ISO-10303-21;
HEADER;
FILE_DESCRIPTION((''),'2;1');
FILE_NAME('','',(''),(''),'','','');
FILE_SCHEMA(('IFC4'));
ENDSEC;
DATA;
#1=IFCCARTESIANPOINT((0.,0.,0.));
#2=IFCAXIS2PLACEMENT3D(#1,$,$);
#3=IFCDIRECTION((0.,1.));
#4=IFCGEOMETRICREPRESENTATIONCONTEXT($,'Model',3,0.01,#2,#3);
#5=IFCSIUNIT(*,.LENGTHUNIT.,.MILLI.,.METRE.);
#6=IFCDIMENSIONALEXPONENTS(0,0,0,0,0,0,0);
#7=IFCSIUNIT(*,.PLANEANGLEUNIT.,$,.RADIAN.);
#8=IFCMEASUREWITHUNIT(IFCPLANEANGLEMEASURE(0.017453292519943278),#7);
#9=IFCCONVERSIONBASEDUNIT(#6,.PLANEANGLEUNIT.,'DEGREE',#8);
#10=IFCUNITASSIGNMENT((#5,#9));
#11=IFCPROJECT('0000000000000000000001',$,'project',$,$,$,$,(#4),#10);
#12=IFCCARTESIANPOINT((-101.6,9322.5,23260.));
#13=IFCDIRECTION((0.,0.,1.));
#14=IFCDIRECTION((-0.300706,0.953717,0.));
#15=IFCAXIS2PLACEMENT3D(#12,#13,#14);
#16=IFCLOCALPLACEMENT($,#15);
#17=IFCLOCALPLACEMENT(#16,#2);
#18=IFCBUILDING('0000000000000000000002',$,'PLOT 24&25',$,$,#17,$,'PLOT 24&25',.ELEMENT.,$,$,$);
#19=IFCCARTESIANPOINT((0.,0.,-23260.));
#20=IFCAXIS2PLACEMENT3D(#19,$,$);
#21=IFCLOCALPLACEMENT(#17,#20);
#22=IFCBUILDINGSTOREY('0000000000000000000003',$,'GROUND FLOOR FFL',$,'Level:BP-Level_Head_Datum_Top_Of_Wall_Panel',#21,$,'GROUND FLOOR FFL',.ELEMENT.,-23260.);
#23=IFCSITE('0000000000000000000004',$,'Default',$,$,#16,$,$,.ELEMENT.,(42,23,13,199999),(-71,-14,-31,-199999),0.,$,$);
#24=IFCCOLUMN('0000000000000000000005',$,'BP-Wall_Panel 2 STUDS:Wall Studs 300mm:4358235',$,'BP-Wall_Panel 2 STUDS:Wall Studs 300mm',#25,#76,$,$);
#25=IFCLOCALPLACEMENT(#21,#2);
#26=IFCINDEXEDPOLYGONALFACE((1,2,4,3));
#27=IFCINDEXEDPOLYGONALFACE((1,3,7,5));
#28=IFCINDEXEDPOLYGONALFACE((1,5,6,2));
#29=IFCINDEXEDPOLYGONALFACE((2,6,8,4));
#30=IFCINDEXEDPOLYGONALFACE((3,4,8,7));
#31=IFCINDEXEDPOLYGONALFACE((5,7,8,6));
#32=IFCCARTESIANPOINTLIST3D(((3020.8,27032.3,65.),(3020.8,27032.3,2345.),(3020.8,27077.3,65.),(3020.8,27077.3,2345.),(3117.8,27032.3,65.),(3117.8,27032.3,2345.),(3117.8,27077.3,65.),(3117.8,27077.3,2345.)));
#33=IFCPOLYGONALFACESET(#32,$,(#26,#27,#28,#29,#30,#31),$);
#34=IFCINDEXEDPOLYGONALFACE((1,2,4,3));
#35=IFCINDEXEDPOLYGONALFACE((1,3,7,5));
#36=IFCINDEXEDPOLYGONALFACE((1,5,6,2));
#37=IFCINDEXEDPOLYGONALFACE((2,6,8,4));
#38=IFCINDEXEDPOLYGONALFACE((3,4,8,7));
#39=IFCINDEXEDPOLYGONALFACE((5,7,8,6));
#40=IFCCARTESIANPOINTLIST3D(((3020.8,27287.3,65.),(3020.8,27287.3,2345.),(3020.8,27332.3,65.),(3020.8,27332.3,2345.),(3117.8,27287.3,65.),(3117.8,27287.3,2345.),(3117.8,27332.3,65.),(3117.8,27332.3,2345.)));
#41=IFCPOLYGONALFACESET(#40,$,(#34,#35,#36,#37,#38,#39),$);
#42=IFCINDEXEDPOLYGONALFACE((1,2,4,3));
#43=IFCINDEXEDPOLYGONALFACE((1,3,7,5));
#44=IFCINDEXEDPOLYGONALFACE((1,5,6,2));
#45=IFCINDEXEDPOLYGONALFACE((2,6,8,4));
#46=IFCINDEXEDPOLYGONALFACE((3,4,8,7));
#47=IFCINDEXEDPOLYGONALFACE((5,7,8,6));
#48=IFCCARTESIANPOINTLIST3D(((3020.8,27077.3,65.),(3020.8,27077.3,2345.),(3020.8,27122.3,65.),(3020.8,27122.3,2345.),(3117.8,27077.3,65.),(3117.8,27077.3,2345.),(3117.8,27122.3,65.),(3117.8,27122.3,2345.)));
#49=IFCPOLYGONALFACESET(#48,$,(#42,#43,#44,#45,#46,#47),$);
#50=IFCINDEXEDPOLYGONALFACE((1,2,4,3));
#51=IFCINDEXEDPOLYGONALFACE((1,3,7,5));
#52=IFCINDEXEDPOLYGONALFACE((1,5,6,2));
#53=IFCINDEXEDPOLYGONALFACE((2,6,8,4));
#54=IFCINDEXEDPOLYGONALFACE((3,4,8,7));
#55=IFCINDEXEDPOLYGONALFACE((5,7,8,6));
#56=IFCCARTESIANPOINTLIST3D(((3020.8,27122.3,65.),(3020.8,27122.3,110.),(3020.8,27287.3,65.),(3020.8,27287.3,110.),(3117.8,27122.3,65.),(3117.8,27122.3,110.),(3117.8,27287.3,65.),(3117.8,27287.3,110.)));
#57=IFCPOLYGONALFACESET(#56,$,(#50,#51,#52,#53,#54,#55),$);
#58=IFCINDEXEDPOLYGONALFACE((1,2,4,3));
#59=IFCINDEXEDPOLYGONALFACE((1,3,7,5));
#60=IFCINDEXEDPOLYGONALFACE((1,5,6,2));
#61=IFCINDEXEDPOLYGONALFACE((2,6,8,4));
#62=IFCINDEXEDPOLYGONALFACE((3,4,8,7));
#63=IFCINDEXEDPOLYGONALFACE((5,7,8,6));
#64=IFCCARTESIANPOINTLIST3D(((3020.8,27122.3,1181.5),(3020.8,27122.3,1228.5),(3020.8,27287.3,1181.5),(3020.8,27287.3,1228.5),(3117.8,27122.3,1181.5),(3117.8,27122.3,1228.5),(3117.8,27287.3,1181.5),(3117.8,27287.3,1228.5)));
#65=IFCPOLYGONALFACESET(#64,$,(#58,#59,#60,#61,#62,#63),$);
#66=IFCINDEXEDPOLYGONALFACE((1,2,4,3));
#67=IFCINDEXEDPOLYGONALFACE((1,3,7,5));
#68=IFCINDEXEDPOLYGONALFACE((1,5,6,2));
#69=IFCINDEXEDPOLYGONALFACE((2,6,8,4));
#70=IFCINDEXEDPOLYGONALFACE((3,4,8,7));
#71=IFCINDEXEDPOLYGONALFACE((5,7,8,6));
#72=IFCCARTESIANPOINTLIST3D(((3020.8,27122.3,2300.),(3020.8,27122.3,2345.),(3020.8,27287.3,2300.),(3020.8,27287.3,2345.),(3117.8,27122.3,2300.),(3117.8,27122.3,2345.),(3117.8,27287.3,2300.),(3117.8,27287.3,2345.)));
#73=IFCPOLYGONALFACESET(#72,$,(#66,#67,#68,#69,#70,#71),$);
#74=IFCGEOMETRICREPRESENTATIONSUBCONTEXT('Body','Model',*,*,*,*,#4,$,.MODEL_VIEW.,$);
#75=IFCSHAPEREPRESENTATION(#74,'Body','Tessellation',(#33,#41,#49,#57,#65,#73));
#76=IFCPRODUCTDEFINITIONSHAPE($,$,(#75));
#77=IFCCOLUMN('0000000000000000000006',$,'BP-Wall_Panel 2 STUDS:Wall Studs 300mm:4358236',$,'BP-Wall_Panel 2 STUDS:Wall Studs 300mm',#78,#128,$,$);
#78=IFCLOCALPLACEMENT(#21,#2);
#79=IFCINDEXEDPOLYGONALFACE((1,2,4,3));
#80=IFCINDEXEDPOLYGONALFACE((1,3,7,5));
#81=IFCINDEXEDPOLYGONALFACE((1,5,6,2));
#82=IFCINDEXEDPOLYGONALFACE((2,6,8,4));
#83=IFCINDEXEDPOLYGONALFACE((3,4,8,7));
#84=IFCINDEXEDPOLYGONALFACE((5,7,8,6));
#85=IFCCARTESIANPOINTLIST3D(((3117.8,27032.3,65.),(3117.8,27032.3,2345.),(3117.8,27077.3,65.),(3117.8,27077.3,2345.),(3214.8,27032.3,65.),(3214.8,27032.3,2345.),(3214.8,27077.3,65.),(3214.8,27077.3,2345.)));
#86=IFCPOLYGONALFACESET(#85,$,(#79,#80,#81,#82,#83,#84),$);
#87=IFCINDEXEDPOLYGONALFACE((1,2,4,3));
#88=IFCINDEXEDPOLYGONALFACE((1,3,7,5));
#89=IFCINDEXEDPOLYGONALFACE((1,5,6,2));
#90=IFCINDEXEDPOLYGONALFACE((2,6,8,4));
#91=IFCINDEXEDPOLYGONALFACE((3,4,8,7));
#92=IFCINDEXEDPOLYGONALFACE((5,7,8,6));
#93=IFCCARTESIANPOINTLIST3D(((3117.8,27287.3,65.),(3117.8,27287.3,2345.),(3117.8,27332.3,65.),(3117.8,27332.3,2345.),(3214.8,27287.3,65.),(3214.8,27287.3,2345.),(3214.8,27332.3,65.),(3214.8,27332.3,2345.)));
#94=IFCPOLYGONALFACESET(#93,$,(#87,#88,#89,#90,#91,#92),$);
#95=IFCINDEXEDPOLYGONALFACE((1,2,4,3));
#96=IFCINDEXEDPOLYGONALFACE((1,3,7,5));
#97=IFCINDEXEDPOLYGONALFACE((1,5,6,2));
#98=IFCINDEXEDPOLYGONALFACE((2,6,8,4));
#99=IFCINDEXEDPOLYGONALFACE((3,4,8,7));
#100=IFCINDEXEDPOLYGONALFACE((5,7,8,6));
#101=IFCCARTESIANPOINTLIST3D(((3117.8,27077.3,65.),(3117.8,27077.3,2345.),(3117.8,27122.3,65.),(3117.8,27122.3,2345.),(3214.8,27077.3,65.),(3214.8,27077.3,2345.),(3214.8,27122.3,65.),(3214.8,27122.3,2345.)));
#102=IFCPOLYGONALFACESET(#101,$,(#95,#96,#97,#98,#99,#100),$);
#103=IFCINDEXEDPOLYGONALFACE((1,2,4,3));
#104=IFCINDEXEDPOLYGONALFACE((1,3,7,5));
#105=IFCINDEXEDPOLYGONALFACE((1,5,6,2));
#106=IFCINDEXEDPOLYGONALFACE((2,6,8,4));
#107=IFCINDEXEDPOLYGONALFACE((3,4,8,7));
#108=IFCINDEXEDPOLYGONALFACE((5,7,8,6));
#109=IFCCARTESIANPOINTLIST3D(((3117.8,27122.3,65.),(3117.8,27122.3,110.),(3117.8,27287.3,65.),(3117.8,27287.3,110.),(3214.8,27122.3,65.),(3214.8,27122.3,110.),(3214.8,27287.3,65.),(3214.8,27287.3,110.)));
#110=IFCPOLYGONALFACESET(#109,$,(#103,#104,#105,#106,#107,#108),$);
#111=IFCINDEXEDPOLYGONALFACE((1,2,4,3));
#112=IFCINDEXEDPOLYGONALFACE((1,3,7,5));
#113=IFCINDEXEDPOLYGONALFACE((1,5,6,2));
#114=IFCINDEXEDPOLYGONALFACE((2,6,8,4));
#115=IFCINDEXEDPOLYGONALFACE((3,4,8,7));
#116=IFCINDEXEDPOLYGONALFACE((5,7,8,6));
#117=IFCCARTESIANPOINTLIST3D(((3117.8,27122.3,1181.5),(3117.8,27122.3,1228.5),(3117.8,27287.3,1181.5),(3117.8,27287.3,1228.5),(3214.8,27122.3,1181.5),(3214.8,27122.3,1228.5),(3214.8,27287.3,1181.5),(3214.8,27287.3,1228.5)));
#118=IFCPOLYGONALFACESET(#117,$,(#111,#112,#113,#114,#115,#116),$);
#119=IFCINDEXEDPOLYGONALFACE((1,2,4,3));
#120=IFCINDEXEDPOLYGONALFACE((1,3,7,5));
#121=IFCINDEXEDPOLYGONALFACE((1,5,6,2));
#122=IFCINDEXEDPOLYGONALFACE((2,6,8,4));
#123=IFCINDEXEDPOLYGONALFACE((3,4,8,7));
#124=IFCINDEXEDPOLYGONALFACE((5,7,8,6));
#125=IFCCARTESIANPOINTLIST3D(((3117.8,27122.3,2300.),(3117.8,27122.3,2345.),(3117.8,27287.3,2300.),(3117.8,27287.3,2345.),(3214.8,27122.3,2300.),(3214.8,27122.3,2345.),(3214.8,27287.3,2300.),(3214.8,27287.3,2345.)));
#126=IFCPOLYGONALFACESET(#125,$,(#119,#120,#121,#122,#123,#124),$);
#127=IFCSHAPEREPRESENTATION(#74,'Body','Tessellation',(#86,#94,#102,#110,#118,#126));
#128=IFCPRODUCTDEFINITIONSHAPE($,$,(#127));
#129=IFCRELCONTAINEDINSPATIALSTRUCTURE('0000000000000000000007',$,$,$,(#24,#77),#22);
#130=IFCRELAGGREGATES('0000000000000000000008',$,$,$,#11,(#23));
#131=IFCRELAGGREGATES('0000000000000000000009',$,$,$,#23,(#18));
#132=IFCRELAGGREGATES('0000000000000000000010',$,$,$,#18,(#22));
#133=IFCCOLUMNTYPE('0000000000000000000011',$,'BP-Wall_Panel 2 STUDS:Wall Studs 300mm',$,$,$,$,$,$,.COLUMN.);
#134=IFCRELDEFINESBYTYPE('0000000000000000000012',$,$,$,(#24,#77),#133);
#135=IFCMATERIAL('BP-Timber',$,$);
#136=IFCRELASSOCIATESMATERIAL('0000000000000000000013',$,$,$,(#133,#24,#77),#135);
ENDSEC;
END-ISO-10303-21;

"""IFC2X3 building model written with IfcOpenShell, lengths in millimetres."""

from ifc_helpers import new_model, entity, si_unit, converted_unit, direction, frame, frame_2d, origin, origin_2d_with_axis, place, context, subcontext, project, spatial, rectangle, extrude, source, transform, mapped, material, type_object, type_shapes, element, save


model = new_model("IFC2X3")

# Units and contexts
model_context = context("Model", 3, precision=0.01, world=origin(), true_north=direction((0.0, 1.0)))
body_context = subcontext(model_context, "Body", "Model", "MODEL_VIEW")
ifc_project = project(units=[si_unit("LENGTHUNIT", "METRE", prefix="MILLI"), converted_unit("PLANEANGLEUNIT", "DEGREE", entity("IfcPlaneAngleMeasure", 0.017453292519943278), si_unit("PLANEANGLEUNIT", "RADIAN"), dimensions=[0, 0, 0, 0, 0, 0, 0])], contexts=[model_context])

# Site, building, storey
site_placement = place(None, frame((-101.6, 9322.5, 23260.0), z_axis=(0.0, 0.0, 1.0), x_axis=(-0.300706, 0.953717, 0.0)))
site = spatial("IfcSite", under=ifc_project, at=site_placement, Name="Default", CompositionType="ELEMENT", RefLatitude=(42, 23, 13, 199999), RefLongitude=(-71, -14, -31, -199999), RefElevation=0.0)
building_placement = place(site_placement, origin())
building = spatial("IfcBuilding", under=site, at=building_placement, Name="PLOT 24&25", LongName="PLOT 24&25", CompositionType="ELEMENT")
storey_placement = place(building_placement, frame((0.0, 0.0, -23260.0)))
storey = spatial("IfcBuildingStorey", under=building, at=storey_placement, Name="GROUND FLOOR FFL", ObjectType="Level:BP-Level_Head_Datum_Top_Of_Wall_Panel", LongName="GROUND FLOOR FFL", CompositionType="ELEMENT", Elevation=-23260.0)

# Columns
ifc_material_1 = material(Name="BP-Timber")
column_type_1 = type_object("IfcColumnType", Name="BP-Wall_Panel 2 STUDS:Wall Studs 300mm", PredefinedType="COLUMN", material=ifc_material_1)
shared_shape_1 = source(origin(), body_context, "Body", "SweptSolid", [
    extrude(rectangle(XDim=97.0, YDim=45.0, at=origin_2d_with_axis()), frame((0.0, -127.5, -23195.0), z_axis=(0.0, 0.0, 1.0), x_axis=(-1.0, 0.0, 0.0)), (0.0, 0.0, 1.0), 2280.0),
    extrude(rectangle(XDim=97.0, YDim=45.0, at=frame_2d((0.0, 0.0), x_axis=(1.0, 0.0))), frame((0.0, 127.5, -23195.0), z_axis=(0.0, 0.0, 1.0), x_axis=(-1.0, 0.0, 0.0)), (0.0, 0.0, 1.0), 2280.0),
    extrude(rectangle(XDim=97.0, YDim=45.0, at=frame_2d((0.0, 0.0), x_axis=(1.0, 0.0))), frame((0.0, -82.5, -23195.0), z_axis=(0.0, 0.0, 1.0), x_axis=(-1.0, 0.0, 0.0)), (0.0, 0.0, 1.0), 2280.0),
    extrude(rectangle(XDim=165.0, YDim=97.0, at=origin_2d_with_axis()), frame((0.0, 22.5, -23195.0), z_axis=(0.0, 0.0, 1.0), x_axis=(0.0, -1.0, 0.0)), (0.0, 0.0, 1.0), 45.0),
    extrude(rectangle(XDim=165.0, YDim=97.0, at=frame_2d((0.0, 0.0), x_axis=(1.0, 0.0))), frame((0.0, 22.5, -22078.5), z_axis=(0.0, 0.0, 1.0), x_axis=(0.0, -1.0, 0.0)), (0.0, 0.0, 1.0), 47.0),
    extrude(rectangle(XDim=165.0, YDim=97.0, at=origin_2d_with_axis()), frame((0.0, 22.5, -20960.0), z_axis=(0.0, 0.0, 1.0), x_axis=(0.0, -1.0, 0.0)), (0.0, 0.0, 1.0), 45.0),
])
type_shapes(column_type_1, [shared_shape_1])
for number, where, name in (
    (1, (3069.3, 27182.3, 23260.0), "BP-Wall_Panel 2 STUDS:Wall Studs 300mm:4358235"),
    (2, (3166.3, 27182.3, 23260.0), "BP-Wall_Panel 2 STUDS:Wall Studs 300mm:4358236"),
):
    element("IfcColumn", number, at=place(storey_placement, frame(where)), inside=storey, type_object=column_type_1, material=ifc_material_1, Name=name, ObjectType="BP-Wall_Panel 2 STUDS:Wall Studs 300mm", context=body_context, shape_type="MappedRepresentation", body=[
        mapped(shared_shape_1, transform((0.0, 0.0, 0.0), scale=1.0)),
    ])

save(model, "model.ifc")
